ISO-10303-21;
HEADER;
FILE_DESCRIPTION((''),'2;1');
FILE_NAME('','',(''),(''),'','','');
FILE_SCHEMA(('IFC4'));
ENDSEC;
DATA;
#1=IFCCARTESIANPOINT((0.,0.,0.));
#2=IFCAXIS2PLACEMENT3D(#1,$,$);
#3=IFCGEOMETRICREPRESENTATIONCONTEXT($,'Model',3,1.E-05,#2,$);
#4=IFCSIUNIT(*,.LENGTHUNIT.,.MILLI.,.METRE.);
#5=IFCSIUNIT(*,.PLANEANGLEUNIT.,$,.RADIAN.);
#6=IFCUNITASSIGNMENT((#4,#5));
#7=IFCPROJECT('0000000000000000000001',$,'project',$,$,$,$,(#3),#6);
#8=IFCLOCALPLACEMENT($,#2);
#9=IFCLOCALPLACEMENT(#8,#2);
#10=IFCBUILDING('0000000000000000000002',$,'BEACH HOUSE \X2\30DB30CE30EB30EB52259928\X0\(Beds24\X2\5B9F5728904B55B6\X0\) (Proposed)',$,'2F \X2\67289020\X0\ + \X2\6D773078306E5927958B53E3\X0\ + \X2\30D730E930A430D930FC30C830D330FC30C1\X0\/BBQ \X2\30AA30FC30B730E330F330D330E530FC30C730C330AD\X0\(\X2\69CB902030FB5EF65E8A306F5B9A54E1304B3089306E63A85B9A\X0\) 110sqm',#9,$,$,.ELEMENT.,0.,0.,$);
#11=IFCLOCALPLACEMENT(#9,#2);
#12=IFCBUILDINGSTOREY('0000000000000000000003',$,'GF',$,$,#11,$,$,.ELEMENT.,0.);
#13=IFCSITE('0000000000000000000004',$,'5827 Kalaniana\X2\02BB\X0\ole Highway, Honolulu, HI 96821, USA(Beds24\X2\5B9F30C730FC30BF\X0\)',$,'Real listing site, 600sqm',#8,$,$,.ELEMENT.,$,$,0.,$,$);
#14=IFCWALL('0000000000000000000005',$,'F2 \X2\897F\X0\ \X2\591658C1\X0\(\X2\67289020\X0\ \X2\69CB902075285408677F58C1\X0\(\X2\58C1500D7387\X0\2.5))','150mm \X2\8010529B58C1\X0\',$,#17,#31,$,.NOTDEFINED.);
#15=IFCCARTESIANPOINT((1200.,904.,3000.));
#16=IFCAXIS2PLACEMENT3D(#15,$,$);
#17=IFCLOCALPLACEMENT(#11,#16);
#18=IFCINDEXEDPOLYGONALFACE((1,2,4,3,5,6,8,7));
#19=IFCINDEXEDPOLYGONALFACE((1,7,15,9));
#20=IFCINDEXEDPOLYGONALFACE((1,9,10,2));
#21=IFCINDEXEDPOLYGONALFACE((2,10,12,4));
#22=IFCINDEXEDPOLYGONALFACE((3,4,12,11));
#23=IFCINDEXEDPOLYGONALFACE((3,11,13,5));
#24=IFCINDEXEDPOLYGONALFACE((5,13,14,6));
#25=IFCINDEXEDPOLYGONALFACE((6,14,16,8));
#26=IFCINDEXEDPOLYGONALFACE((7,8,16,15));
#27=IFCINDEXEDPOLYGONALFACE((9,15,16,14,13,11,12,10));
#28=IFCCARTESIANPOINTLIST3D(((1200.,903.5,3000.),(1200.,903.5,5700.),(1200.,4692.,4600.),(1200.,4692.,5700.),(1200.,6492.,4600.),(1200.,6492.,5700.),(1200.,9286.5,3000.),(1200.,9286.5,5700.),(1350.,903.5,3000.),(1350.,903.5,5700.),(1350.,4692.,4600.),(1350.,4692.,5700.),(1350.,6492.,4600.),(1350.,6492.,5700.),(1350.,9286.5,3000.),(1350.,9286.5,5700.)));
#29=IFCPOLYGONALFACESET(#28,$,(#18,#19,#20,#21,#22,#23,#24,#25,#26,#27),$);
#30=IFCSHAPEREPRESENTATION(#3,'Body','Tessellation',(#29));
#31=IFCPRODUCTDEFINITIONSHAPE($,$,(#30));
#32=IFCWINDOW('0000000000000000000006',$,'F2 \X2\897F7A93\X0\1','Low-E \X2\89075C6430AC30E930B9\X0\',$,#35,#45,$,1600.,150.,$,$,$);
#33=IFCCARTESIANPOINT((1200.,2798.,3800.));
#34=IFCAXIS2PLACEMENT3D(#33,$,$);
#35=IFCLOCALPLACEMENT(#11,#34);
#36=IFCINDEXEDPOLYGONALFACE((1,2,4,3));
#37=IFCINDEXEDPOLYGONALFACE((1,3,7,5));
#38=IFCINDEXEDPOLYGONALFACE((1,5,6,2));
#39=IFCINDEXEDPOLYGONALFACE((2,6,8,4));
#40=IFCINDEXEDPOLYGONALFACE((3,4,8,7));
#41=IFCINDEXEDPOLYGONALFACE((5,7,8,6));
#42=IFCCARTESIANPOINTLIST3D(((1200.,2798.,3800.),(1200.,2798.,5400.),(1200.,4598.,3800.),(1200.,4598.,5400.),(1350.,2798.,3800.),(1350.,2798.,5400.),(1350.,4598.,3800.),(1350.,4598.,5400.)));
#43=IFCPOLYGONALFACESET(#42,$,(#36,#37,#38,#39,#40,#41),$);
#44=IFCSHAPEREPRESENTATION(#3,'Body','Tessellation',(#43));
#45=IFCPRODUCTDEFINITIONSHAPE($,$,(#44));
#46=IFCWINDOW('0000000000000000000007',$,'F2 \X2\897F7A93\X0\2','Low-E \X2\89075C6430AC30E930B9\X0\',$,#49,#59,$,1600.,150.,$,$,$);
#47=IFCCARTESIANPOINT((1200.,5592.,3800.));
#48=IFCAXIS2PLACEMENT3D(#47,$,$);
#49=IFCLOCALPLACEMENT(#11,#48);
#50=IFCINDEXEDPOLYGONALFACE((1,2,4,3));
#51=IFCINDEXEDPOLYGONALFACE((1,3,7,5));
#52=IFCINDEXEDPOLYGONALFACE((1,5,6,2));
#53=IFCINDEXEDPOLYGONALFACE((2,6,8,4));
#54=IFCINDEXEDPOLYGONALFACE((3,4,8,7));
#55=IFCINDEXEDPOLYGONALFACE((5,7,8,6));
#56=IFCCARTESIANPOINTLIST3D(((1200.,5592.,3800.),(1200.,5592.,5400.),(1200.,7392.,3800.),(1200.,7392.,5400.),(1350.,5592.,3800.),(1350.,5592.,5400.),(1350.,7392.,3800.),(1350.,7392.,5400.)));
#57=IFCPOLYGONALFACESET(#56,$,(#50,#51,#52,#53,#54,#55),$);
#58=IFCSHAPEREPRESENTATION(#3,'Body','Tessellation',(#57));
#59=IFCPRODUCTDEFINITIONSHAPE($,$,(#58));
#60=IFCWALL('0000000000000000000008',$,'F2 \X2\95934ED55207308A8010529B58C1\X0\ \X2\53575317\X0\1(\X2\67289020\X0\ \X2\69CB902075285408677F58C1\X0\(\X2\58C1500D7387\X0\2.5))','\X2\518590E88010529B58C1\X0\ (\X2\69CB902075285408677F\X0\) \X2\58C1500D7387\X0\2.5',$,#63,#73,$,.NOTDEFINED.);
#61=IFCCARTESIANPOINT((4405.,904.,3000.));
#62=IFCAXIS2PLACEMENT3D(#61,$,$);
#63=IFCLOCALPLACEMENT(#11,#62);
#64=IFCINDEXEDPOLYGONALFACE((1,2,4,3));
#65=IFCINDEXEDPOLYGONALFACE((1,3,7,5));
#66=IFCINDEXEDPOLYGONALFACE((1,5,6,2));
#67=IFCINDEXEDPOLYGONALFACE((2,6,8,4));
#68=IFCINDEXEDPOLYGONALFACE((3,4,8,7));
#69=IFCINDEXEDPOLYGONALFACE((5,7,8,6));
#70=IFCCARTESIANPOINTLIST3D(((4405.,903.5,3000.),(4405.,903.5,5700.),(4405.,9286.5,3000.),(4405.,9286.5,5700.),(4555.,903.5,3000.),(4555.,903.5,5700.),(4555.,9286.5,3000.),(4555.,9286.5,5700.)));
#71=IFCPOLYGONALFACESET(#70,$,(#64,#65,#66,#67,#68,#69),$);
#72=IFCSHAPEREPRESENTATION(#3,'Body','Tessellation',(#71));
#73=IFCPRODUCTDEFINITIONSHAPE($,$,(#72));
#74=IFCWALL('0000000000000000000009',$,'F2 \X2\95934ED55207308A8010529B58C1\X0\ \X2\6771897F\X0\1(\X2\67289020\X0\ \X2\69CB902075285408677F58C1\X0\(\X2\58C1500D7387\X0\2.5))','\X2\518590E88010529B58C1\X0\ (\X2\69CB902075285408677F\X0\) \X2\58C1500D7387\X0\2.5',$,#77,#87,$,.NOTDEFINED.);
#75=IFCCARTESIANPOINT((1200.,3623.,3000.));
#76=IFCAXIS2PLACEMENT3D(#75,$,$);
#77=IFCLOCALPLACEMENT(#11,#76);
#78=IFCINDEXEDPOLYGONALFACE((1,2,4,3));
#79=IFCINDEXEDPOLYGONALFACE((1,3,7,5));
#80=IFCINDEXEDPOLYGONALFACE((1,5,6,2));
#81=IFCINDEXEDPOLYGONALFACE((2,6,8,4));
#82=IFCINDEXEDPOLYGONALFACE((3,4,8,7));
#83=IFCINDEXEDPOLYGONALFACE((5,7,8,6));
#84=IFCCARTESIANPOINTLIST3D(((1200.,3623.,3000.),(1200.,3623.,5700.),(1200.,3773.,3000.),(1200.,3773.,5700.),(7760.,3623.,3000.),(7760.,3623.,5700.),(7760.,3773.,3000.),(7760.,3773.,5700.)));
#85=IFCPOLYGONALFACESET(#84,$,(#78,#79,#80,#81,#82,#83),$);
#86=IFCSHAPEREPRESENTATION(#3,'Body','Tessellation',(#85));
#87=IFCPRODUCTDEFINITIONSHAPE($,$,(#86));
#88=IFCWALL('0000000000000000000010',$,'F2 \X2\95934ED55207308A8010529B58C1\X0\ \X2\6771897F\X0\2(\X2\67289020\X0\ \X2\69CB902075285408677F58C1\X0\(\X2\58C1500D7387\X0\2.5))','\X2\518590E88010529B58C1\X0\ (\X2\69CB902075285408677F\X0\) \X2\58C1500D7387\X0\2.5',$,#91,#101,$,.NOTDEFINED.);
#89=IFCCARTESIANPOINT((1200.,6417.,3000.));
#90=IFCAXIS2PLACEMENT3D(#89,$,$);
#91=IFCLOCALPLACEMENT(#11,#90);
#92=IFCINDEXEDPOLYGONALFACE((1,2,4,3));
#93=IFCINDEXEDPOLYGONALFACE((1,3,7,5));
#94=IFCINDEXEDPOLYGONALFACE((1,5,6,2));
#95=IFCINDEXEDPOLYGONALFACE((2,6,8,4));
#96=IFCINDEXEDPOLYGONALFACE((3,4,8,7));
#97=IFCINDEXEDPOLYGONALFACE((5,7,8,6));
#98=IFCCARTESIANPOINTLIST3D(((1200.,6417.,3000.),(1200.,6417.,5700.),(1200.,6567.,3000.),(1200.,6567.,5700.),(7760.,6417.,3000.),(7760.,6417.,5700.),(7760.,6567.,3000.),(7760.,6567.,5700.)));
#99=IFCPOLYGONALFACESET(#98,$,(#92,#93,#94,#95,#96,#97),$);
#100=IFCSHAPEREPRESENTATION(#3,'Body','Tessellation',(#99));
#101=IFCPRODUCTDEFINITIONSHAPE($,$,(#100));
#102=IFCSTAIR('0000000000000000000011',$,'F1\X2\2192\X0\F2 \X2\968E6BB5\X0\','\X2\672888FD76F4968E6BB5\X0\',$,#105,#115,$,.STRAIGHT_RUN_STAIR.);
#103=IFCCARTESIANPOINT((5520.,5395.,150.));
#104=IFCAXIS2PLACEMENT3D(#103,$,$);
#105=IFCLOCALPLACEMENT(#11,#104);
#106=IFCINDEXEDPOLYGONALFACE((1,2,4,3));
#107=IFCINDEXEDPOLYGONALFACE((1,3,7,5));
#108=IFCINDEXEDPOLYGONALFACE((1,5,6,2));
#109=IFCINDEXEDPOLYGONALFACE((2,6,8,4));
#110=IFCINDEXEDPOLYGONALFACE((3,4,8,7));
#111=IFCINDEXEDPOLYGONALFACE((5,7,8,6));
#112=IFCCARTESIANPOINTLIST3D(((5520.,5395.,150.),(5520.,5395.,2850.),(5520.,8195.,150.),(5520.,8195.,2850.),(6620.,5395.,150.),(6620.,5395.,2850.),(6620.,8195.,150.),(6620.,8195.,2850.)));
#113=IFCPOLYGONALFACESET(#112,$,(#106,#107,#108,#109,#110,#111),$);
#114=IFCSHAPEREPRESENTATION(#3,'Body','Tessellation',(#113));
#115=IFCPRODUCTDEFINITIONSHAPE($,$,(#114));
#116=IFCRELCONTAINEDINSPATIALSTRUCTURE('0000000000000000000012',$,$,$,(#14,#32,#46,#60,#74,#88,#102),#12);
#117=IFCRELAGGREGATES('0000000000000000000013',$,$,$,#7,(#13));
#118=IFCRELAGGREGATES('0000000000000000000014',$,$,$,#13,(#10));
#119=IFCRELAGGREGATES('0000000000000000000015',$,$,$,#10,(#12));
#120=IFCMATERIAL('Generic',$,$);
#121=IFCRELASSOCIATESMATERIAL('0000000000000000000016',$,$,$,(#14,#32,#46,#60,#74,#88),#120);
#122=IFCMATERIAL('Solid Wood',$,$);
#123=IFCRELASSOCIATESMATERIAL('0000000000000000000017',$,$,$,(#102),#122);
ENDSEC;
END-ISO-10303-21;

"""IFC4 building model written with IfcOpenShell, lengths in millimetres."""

from ifc_helpers import new_model, si_unit, frame, frame_2d, origin, place, context, project, spatial, rectangle, extrude, material, element, fill, save


model = new_model("IFC4")

# Units and contexts
model_context = context("Model", 3, precision=1e-05, world=origin())
ifc_project = project(units=[si_unit("LENGTHUNIT", "METRE", prefix="MILLI"), si_unit("PLANEANGLEUNIT", "RADIAN")], contexts=[model_context])

# Site, building, storey
site_placement = place(None, origin())
site = spatial("IfcSite", under=ifc_project, at=site_placement, Name="5827 Kalanianaʻole Highway, Honolulu, HI 96821, USA(Beds24実データ)", ObjectType="Real listing site, 600sqm", CompositionType="ELEMENT", RefElevation=0.0)
building_placement = place(site_placement, origin())
building = spatial("IfcBuilding", under=site, at=building_placement, Name="BEACH HOUSE ホノルル別館(Beds24実在運営) (Proposed)", ObjectType="2F 木造 + 海への大開口 + プライベートビーチ/BBQ オーシャンビューデッキ(構造・延床は定員からの推定) 110sqm", CompositionType="ELEMENT", ElevationOfRefHeight=0.0, ElevationOfTerrain=0.0)
storey_placement = place(building_placement, origin())
storey = spatial("IfcBuildingStorey", under=building, at=storey_placement, Name="GF", CompositionType="ELEMENT", Elevation=0.0)

# Shared definitions
ifc_material_1 = material(Name="Generic")

# Wall, openings, windows
wall_1_placement = place(storey_placement, frame((1200.0, 904.0, 3000.0)))
wall_1 = element("IfcWall", 1, at=wall_1_placement, inside=storey, material=ifc_material_1, Name="F2 西 外壁(木造 構造用合板壁(壁倍率2.5))", Description="150mm 耐力壁", PredefinedType="NOTDEFINED", context=model_context, shape_type="SweptSolid", body=[
    extrude(rectangle(XDim=150.0, YDim=8383.0, at=frame_2d((75.0, 4191.0))), frame((1200.0, 904.0, 3000.0)), (0.0, 0.0, 1.0), 2700.0),
])
opening_1_placement = place(storey_placement, frame((1200.0, 2798.0, 3800.0)))
opening_1 = element("IfcOpeningElement", 2, at=opening_1_placement, cuts=wall_1, PredefinedType="NOTDEFINED", context=model_context, shape_type="SweptSolid", body=[
    extrude(rectangle(XDim=150.0, YDim=1800.0, at=frame_2d((75.0, 900.0))), frame((1200.0, 2798.0, 3800.0)), (0.0, 0.0, 1.0), 1600.0),
])
opening_2_placement = place(storey_placement, frame((1200.0, 5592.0, 3800.0)))
opening_2 = element("IfcOpeningElement", 3, at=opening_2_placement, cuts=wall_1, PredefinedType="NOTDEFINED", context=model_context, shape_type="SweptSolid", body=[
    extrude(rectangle(XDim=150.0, YDim=1800.0, at=frame_2d((75.0, 900.0))), frame((1200.0, 5592.0, 3800.0)), (0.0, 0.0, 1.0), 1600.0),
])
window_1_placement = place(storey_placement, frame((1200.0, 2798.0, 3800.0)))
window_1 = element("IfcWindow", 4, at=window_1_placement, inside=storey, material=ifc_material_1, Name="F2 西窓1", Description="Low-E 複層ガラス", OverallHeight=1600.0, OverallWidth=150.0, context=model_context, shape_type="SweptSolid", body=[
    extrude(rectangle(XDim=150.0, YDim=1800.0, at=frame_2d((75.0, 900.0))), frame((1200.0, 2798.0, 3800.0)), (0.0, 0.0, 1.0), 1600.0),
])
fill(opening_1, window_1)
window_2_placement = place(storey_placement, frame((1200.0, 5592.0, 3800.0)))
window_2 = element("IfcWindow", 5, at=window_2_placement, inside=storey, material=ifc_material_1, Name="F2 西窓2", Description="Low-E 複層ガラス", OverallHeight=1600.0, OverallWidth=150.0, context=model_context, shape_type="SweptSolid", body=[
    extrude(rectangle(XDim=150.0, YDim=1800.0, at=frame_2d((75.0, 900.0))), frame((1200.0, 5592.0, 3800.0)), (0.0, 0.0, 1.0), 1600.0),
])
fill(opening_2, window_2)

# Walls
wall_2_placement = place(storey_placement, frame((4405.0, 904.0, 3000.0)))
element("IfcWall", 6, at=wall_2_placement, inside=storey, material=ifc_material_1, Name="F2 間仕切り耐力壁 南北1(木造 構造用合板壁(壁倍率2.5))", Description="内部耐力壁 (構造用合板) 壁倍率2.5", PredefinedType="NOTDEFINED", context=model_context, shape_type="SweptSolid", body=[
    extrude(rectangle(XDim=150.0, YDim=8383.0, at=frame_2d((75.0, 4191.0))), frame((4405.0, 904.0, 3000.0)), (0.0, 0.0, 1.0), 2700.0),
])
wall_3_placement = place(storey_placement, frame((1200.0, 3623.0, 3000.0)))
element("IfcWall", 7, at=wall_3_placement, inside=storey, material=ifc_material_1, Name="F2 間仕切り耐力壁 東西1(木造 構造用合板壁(壁倍率2.5))", Description="内部耐力壁 (構造用合板) 壁倍率2.5", PredefinedType="NOTDEFINED", context=model_context, shape_type="SweptSolid", body=[
    extrude(rectangle(XDim=6560.0, YDim=150.0, at=frame_2d((3280.0, 75.0))), frame((1200.0, 3623.0, 3000.0)), (0.0, 0.0, 1.0), 2700.0),
])
wall_4_placement = place(storey_placement, frame((1200.0, 6417.0, 3000.0)))
element("IfcWall", 8, at=wall_4_placement, inside=storey, material=ifc_material_1, Name="F2 間仕切り耐力壁 東西2(木造 構造用合板壁(壁倍率2.5))", Description="内部耐力壁 (構造用合板) 壁倍率2.5", PredefinedType="NOTDEFINED", context=model_context, shape_type="SweptSolid", body=[
    extrude(rectangle(XDim=6560.0, YDim=150.0, at=frame_2d((3280.0, 75.0))), frame((1200.0, 6417.0, 3000.0)), (0.0, 0.0, 1.0), 2700.0),
])

# Stair
ifc_material_2 = material(Name="Solid Wood")
stair_placement = place(storey_placement, frame((5520.0, 5395.0, 150.0)))
element("IfcStair", 9, at=stair_placement, inside=storey, material=ifc_material_2, Name="F1→F2 階段", Description="木製直階段", PredefinedType="STRAIGHT_RUN_STAIR", context=model_context, shape_type="SweptSolid", body=[
    extrude(rectangle(XDim=1100.0, YDim=2800.0, at=frame_2d((550.0, 1400.0))), frame((5520.0, 5395.0, 150.0)), (0.0, 0.0, 1.0), 2700.0),
])

save(model, "model.ifc")
